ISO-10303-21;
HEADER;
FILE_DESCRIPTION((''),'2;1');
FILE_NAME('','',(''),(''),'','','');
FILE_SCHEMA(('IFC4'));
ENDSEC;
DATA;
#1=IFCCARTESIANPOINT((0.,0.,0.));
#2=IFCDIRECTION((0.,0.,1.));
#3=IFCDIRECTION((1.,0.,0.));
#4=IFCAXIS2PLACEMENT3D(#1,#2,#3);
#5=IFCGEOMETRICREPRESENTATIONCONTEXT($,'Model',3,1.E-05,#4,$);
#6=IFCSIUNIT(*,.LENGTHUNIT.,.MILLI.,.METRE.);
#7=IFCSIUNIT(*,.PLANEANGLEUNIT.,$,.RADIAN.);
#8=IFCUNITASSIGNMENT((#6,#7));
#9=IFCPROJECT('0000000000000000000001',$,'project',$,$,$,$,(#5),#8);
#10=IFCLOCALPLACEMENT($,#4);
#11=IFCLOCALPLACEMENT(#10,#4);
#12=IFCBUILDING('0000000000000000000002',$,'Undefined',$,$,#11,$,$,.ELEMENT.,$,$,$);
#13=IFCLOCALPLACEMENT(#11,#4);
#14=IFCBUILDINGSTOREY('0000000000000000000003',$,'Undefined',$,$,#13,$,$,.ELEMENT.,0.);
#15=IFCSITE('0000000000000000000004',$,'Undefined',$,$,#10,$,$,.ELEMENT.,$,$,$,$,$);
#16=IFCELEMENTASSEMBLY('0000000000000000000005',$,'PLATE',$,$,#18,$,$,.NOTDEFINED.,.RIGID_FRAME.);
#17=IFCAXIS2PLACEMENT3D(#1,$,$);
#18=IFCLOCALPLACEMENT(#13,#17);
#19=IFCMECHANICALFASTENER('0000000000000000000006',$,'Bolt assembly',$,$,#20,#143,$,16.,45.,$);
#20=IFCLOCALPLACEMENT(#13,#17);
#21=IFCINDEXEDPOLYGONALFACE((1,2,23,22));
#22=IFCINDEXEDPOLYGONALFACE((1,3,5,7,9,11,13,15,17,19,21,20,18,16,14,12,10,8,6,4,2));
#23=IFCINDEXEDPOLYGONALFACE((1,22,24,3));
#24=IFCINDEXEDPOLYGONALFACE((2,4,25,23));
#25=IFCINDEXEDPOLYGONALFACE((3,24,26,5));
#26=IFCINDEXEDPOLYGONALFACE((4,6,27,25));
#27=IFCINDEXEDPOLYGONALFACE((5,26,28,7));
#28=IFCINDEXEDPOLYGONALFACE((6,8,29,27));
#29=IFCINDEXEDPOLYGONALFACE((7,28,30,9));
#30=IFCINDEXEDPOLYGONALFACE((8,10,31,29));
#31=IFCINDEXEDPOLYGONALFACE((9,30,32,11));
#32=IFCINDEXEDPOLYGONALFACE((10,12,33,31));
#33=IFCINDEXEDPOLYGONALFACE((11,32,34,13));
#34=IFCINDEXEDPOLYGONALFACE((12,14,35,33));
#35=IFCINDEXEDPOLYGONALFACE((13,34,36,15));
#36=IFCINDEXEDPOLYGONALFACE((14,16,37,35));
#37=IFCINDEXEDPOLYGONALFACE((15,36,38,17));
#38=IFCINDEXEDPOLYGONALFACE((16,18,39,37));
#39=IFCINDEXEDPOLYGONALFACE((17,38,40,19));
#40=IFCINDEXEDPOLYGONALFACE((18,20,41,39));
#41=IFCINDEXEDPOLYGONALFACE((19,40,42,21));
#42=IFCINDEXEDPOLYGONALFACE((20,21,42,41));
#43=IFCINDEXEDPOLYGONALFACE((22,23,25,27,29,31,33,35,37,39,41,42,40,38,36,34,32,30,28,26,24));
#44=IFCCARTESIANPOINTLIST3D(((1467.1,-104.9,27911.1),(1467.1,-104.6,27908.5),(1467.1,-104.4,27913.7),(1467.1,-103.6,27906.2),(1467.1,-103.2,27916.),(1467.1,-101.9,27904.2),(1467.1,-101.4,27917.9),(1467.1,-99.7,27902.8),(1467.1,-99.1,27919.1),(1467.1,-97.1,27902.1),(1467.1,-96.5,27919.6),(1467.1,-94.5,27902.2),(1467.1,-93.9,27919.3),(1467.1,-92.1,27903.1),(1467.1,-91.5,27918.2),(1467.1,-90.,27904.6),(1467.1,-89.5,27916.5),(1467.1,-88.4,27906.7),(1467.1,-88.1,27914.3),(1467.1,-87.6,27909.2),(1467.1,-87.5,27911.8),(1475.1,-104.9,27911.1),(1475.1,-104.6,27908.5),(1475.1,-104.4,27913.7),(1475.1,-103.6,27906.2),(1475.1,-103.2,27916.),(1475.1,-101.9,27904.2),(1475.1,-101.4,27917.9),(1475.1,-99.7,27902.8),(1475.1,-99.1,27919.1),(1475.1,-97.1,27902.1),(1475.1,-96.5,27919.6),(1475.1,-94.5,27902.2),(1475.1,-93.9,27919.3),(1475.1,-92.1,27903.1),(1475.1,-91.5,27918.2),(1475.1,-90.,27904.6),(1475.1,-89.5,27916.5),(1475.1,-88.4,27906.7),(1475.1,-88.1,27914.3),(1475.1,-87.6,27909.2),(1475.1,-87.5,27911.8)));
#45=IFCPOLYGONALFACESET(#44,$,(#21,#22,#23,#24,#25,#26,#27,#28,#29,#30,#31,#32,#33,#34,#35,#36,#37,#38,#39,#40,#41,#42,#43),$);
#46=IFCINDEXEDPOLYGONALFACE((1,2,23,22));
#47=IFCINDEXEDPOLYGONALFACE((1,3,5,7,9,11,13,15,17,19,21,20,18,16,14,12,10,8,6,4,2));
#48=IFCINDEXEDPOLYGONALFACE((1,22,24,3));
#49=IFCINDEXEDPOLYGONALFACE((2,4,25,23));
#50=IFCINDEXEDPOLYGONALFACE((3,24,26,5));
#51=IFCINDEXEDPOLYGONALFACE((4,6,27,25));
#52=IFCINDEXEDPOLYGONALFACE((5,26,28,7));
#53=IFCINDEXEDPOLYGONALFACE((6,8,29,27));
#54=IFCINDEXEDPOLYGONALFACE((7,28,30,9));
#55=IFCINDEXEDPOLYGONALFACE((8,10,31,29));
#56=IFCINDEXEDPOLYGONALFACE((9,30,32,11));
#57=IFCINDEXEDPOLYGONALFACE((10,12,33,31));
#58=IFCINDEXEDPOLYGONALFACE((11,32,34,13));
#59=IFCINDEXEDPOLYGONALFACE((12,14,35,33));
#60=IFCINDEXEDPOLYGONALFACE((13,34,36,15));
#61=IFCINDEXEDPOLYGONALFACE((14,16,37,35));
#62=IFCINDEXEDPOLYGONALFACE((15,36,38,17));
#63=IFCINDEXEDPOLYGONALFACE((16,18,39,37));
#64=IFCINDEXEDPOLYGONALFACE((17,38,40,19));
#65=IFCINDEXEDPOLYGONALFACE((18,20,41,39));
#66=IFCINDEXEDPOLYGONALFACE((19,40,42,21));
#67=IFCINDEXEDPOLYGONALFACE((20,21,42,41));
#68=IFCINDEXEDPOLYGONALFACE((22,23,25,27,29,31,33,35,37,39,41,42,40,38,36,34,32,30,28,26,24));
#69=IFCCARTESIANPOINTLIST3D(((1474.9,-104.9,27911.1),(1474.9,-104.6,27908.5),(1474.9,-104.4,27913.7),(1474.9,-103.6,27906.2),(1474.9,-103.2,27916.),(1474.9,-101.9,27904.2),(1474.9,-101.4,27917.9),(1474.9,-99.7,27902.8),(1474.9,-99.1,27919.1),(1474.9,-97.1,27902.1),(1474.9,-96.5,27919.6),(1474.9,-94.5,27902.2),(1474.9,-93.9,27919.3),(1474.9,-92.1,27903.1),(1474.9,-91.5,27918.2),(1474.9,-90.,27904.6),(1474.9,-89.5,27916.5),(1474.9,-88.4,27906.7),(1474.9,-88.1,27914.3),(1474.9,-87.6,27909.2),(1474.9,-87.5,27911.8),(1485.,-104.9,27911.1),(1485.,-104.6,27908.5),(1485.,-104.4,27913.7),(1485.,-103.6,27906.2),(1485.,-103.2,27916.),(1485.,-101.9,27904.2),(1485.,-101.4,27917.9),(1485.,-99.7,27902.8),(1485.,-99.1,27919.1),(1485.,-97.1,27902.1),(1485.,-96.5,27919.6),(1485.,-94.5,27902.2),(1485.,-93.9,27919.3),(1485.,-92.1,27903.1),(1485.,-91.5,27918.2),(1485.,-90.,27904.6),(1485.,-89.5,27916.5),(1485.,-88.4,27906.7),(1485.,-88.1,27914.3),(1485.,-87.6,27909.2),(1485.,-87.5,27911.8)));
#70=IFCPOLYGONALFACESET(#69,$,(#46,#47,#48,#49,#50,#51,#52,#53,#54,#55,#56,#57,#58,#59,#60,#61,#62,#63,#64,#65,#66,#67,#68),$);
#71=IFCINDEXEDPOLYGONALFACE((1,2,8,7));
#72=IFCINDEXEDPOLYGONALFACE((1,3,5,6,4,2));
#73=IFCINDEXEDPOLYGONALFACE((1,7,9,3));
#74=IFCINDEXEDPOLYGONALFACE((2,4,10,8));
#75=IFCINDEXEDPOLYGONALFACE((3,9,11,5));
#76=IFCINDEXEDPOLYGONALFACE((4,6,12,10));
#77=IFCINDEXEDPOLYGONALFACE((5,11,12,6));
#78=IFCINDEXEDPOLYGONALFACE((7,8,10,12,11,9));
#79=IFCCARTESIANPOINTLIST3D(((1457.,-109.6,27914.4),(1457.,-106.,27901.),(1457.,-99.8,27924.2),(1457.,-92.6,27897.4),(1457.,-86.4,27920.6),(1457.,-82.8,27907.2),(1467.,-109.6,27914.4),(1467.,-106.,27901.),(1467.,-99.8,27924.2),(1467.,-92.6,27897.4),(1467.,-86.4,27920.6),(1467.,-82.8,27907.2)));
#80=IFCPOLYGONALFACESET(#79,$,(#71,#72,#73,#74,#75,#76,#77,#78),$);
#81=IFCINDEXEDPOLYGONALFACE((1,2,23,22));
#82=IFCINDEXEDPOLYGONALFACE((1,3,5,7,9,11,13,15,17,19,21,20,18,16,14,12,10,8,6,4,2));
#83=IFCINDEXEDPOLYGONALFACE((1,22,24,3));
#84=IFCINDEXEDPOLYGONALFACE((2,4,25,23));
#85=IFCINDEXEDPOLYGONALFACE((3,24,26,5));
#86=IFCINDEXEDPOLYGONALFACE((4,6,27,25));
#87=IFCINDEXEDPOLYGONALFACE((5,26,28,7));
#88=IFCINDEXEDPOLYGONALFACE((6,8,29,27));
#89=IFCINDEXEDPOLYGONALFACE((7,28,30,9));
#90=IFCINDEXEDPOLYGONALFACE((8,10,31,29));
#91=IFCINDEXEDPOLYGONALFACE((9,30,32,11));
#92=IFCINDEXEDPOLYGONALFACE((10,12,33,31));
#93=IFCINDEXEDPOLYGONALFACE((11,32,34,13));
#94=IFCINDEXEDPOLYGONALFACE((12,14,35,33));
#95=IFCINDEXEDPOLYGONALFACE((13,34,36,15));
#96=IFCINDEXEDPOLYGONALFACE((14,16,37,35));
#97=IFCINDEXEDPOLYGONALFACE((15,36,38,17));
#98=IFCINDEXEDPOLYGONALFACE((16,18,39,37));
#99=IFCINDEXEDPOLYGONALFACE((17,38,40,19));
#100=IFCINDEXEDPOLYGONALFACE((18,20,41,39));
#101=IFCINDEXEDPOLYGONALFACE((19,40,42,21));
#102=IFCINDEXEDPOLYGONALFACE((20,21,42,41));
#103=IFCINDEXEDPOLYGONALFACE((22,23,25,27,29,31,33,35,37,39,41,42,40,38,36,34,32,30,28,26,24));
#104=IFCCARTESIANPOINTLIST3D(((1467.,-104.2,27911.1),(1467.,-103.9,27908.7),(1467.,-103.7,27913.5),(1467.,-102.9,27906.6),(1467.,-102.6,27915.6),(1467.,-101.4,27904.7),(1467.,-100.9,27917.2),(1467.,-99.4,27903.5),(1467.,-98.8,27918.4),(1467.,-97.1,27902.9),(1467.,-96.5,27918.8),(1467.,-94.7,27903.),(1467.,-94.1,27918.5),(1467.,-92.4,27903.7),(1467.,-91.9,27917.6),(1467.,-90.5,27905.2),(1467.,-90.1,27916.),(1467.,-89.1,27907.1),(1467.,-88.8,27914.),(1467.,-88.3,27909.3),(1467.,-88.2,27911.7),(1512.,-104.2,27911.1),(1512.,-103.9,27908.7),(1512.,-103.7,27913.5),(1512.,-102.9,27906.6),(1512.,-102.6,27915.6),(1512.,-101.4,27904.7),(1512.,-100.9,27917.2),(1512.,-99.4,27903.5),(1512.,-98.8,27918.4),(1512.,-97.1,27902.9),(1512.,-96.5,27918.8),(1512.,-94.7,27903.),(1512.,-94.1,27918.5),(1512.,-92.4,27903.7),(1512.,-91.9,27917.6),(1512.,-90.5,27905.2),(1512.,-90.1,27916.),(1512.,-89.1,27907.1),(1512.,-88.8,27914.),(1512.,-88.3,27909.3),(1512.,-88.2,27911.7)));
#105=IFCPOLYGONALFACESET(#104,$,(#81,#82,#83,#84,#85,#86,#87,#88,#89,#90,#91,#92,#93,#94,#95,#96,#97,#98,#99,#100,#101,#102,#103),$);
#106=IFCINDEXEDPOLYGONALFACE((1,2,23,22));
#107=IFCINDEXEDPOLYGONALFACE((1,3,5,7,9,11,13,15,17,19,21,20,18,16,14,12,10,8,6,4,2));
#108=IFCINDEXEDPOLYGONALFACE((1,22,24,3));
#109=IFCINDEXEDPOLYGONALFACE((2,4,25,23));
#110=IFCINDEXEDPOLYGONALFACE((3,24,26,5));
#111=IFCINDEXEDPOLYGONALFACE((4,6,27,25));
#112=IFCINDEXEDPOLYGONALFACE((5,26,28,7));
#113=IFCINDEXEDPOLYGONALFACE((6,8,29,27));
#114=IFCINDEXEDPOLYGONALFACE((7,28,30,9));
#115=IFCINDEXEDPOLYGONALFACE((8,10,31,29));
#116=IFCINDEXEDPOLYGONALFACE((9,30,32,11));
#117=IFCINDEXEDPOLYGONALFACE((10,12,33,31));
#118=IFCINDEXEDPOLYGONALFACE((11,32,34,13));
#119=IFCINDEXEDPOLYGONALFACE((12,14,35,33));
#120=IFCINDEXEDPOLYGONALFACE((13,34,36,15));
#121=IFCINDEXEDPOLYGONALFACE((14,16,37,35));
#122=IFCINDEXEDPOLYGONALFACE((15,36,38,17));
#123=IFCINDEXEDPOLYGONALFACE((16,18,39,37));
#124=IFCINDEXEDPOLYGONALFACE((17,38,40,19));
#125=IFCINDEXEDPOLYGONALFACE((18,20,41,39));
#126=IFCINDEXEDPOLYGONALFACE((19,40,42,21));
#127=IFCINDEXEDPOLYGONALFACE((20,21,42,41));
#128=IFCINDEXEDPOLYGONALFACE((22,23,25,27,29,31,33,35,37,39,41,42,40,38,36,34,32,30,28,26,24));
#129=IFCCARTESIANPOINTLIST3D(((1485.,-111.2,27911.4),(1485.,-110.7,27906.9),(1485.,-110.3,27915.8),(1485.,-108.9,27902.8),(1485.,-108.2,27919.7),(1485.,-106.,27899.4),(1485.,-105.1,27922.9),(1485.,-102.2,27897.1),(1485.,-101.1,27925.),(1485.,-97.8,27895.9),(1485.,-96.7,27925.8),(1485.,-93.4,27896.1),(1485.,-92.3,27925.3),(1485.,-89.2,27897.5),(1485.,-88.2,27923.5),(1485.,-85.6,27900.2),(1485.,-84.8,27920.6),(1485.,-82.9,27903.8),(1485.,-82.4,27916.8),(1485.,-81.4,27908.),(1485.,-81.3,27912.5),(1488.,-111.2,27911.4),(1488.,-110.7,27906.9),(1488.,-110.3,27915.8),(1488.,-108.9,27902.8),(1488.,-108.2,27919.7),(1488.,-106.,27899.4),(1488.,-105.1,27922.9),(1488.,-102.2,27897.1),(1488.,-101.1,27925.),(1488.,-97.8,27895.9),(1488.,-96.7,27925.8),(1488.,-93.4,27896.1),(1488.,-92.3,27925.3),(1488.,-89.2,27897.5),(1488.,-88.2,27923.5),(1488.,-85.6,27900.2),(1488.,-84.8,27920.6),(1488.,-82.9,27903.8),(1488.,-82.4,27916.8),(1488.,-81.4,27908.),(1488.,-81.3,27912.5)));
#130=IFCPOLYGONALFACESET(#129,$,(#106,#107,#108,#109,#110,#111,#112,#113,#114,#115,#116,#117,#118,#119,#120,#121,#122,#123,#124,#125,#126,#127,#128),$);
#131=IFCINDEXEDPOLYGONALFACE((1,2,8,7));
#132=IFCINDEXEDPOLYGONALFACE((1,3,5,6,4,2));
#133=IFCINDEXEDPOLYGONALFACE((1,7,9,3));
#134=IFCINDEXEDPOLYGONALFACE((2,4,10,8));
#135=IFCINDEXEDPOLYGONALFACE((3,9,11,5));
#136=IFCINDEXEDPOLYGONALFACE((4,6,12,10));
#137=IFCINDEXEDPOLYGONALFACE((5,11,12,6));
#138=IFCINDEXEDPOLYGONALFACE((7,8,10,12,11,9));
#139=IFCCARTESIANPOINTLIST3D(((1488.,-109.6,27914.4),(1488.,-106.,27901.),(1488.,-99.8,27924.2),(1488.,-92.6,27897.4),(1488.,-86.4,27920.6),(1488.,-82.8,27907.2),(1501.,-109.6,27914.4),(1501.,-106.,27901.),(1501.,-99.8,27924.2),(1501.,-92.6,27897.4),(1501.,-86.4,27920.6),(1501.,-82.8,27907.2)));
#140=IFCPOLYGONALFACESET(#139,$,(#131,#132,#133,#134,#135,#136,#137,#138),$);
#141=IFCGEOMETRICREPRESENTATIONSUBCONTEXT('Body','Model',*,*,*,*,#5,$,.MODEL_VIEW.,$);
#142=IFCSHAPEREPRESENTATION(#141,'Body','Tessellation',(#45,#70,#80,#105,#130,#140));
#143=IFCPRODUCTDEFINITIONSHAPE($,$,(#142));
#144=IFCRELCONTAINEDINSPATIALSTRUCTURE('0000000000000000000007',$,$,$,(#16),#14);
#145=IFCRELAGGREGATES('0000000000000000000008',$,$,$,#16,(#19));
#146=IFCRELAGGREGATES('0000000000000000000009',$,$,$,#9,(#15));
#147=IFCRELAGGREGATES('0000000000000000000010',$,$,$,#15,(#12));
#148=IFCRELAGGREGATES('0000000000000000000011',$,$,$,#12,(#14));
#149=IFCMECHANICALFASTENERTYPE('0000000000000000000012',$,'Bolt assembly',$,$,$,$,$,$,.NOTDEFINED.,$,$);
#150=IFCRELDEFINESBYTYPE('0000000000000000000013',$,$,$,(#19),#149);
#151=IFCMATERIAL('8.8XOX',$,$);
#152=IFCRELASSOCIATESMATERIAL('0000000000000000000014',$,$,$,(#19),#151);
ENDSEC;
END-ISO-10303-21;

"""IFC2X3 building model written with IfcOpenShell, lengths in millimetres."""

from ifc_helpers import new_model, si_unit, frame, origin_with_axes, origin_2d_with_axis, place, context, subcontext, project, spatial, polyline, circle, outline, extrude, source, transform, mapped, material, type_object, element, aggregate, save


model = new_model("IFC2X3")

# Units and contexts
model_context = context("Model", 3, precision=1e-05, world=origin_with_axes())
body_context = subcontext(model_context, "Body", "Model", "MODEL_VIEW")
ifc_project = project(units=[si_unit("LENGTHUNIT", "METRE", prefix="MILLI"), si_unit("PLANEANGLEUNIT", "RADIAN")], contexts=[model_context])

# Site, building, storey
site_placement = place(None, origin_with_axes())
site = spatial("IfcSite", under=ifc_project, at=site_placement, Name="Undefined", CompositionType="ELEMENT")
building_placement = place(site_placement, origin_with_axes())
building = spatial("IfcBuilding", under=site, at=building_placement, Name="Undefined", CompositionType="ELEMENT")
storey_placement = place(building_placement, origin_with_axes())
storey = spatial("IfcBuildingStorey", under=building, at=storey_placement, Name="Undefined", CompositionType="ELEMENT", Elevation=0.0)

# Element assembly
assembly_1_placement = place(storey_placement, origin_with_axes())
assembly_1 = element("IfcElementAssembly", 1, at=assembly_1_placement, inside=storey, Name="PLATE", AssemblyPlace="NOTDEFINED", PredefinedType="RIGID_FRAME")

# Mechanical fastener
ifc_material_1 = material(Name="8.8XOX")
mechanical_fastener_type = type_object("IfcMechanicalFastenerType", Name="Bolt assembly")
shared_shape = source(origin_with_axes(), body_context, "Body", "SweptSolid", [
    extrude(circle(Radius=8.8, at=origin_2d_with_axis()), frame((0.0, 7.1, 0.0), z_axis=(0.0, 1.0, 0.0), x_axis=(1.0, 0.0, 0.0)), (0.0, 0.0, 1.0), 8.0),
    extrude(circle(Radius=8.8, at=origin_2d_with_axis()), frame((0.0, 14.9, 0.0), z_axis=(0.0, 1.0, 0.0), x_axis=(1.0, 0.0, 0.0)), (0.0, 0.0, 1.0), 10.1),
    extrude(outline(polyline([(12.0, -6.9), (12.0, 6.9), (0.0, 13.9), (-12.0, 6.9), (-12.0, -6.9), (0.0, -13.9), (12.0, -6.9)])), frame((0.0, -3.0, 0.0), z_axis=(0.0, 1.0, 0.0), x_axis=(1.0, 0.0, 0.0)), (0.0, 0.0, 1.0), 10.0),
    extrude(circle(Radius=8.0, at=origin_2d_with_axis()), frame((0.0, 7.0, 0.0), z_axis=(0.0, 1.0, 0.0), x_axis=(1.0, 0.0, 0.0)), (0.0, 0.0, 1.0), 45.0),
    extrude(circle(Radius=15.0, at=origin_2d_with_axis()), frame((0.0, 25.0, 0.0), z_axis=(0.0, 1.0, 0.0), x_axis=(1.0, 0.0, 0.0)), (0.0, 0.0, 1.0), 3.0),
    extrude(outline(polyline([(12.0, -6.9), (12.0, 6.9), (0.0, 13.9), (-12.0, 6.9), (-12.0, -6.9), (0.0, -13.9), (12.0, -6.9)])), frame((0.0, 28.0, 0.0), z_axis=(0.0, 1.0, 0.0), x_axis=(1.0, 0.0, 0.0)), (0.0, 0.0, 1.0), 13.0),
])
mechanical_fastener_1_placement = place(assembly_1_placement, frame((1460.0, -96.2, 27910.8), z_axis=(0.0, -0.707107, -0.707107), x_axis=(0.0, 0.707107, -0.707107)))
mechanical_fastener_1 = element("IfcMechanicalFastener", 2, at=mechanical_fastener_1_placement, type_object=mechanical_fastener_type, material=ifc_material_1, Name="Bolt assembly", NominalDiameter=16.0, NominalLength=45.0, context=body_context, shape_type="MappedRepresentation", body=[
    mapped(shared_shape, transform((0.0, 0.0, 0.0))),
])
aggregate(assembly_1, [mechanical_fastener_1])

save(model, "model.ifc")
